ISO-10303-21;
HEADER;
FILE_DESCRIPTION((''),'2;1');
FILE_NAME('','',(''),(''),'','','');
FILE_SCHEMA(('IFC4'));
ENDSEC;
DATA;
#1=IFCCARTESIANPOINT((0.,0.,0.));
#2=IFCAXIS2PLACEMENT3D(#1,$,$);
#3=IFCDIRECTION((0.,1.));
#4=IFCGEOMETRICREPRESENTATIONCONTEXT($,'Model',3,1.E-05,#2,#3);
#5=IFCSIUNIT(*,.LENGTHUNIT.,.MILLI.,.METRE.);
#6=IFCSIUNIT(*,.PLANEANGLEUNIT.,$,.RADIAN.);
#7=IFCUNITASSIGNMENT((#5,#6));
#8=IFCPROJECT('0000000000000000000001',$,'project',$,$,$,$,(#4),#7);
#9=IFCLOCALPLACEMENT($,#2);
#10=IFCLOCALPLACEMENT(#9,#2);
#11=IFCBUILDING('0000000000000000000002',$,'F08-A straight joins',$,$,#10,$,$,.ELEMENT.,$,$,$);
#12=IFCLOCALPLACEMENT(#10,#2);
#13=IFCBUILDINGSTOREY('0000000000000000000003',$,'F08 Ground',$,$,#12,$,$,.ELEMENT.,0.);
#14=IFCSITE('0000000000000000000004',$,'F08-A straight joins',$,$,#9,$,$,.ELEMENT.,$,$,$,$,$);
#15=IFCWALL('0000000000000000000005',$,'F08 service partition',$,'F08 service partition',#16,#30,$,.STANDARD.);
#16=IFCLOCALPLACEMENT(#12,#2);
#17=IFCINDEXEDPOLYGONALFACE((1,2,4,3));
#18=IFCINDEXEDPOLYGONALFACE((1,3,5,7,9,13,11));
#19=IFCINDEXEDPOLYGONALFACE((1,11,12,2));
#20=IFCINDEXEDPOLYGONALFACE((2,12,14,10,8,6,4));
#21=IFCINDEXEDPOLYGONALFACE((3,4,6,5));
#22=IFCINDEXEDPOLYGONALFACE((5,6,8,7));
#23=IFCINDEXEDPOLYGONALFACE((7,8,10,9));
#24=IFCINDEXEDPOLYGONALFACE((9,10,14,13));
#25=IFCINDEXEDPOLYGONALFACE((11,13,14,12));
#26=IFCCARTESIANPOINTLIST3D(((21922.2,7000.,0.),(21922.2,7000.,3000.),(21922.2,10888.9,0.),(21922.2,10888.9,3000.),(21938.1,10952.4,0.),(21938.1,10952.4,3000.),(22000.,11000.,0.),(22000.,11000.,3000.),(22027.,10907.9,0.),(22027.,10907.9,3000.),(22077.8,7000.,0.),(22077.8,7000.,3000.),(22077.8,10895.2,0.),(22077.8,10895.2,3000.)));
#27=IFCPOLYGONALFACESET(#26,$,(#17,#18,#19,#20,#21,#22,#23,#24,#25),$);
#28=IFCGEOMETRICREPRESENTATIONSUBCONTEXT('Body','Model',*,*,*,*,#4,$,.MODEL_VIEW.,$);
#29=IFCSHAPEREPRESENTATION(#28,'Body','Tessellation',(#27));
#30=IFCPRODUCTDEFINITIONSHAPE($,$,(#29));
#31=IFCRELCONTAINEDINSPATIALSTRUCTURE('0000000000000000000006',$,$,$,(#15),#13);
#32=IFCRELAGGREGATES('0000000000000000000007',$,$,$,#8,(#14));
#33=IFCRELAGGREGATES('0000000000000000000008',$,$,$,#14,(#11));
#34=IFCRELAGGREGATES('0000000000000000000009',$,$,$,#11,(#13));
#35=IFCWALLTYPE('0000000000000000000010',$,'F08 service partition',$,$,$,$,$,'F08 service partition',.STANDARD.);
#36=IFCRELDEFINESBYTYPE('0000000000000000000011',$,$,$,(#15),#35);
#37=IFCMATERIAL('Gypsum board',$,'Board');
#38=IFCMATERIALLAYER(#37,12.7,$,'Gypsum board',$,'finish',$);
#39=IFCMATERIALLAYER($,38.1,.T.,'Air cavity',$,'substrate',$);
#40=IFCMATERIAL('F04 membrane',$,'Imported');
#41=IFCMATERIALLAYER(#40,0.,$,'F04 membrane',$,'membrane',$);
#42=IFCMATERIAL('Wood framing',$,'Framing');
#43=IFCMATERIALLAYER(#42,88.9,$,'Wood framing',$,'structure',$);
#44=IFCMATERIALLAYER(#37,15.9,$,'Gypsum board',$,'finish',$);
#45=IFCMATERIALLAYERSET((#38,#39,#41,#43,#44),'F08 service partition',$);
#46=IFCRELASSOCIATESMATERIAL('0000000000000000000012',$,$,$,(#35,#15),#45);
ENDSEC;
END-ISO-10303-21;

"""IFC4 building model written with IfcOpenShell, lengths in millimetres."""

from ifc_helpers import new_model, si_unit, direction, frame, origin, place, context, subcontext, project, spatial, polyline, outline, extrude, material, layer, layer_set, layer_usage, type_object, element, save


model = new_model("IFC4")

# Units and contexts
model_context = context("Model", 3, precision=1e-05, world=origin(), true_north=direction((0.0, 1.0)))
body_context = subcontext(model_context, "Body", "Model", "MODEL_VIEW")
ifc_project = project(units=[si_unit("LENGTHUNIT", "METRE", prefix="MILLI"), si_unit("PLANEANGLEUNIT", "RADIAN")], contexts=[model_context])

# Site, building, storey
site_placement = place(None, origin())
site = spatial("IfcSite", under=ifc_project, at=site_placement, Name="F08-A straight joins", CompositionType="ELEMENT")
building_placement = place(site_placement, origin())
building = spatial("IfcBuilding", under=site, at=building_placement, Name="F08-A straight joins", CompositionType="ELEMENT")
storey_placement = place(building_placement, origin())
storey = spatial("IfcBuildingStorey", under=building, at=storey_placement, Name="F08 Ground", CompositionType="ELEMENT", Elevation=0.0)

# Shared definitions
ifc_material_1 = material(Name="F04 membrane", Category="Imported")
ifc_material_2 = material(Name="Wood framing", Category="Framing")
ifc_material_3 = material(Name="Gypsum board", Category="Board")

# Wall
ifc_layer_1 = layer(ifc_material_3, 12.7, Name="Gypsum board", Category="finish")
ifc_layer_2 = layer(None, 38.1, ventilated=True, Name="Air cavity", Category="substrate")
ifc_layer_3 = layer(ifc_material_1, 0.0, Name="F04 membrane", Category="membrane")
ifc_layer_4 = layer(ifc_material_2, 88.9, Name="Wood framing", Category="structure")
ifc_layer_5 = layer(ifc_material_3, 15.9, Name="Gypsum board", Category="finish")
ifc_layer_set_1 = layer_set([ifc_layer_1, ifc_layer_2, ifc_layer_3, ifc_layer_4, ifc_layer_5], Name="F08 service partition")
wall_type_1 = type_object("IfcWallType", Name="F08 service partition", ElementType="F08 service partition", PredefinedType="STANDARD", material=ifc_layer_set_1)
ifc_layer_usage_1 = layer_usage(ifc_layer_set_1, "AXIS2", "NEGATIVE", 77.8)
wall_1_placement = place(storey_placement, frame((22000.0, 11000.0, 0.0), z_axis=(0.0, 0.0, 1.0), x_axis=(0.0, -1.0, 0.0)))
element("IfcWall", 1, at=wall_1_placement, inside=storey, type_object=wall_type_1, material=ifc_layer_usage_1, Name="F08 service partition", ObjectType="F08 service partition", PredefinedType="STANDARD", context=body_context, shape_type="SweptSolid", body=[
    extrude(outline(polyline([(111.1, -77.8), (4000.0, -77.8), (4000.0, 77.8), (104.8, 77.8), (92.1, 27.0), (0.0, 0.0), (47.6, -61.9), (111.1, -77.8)])), origin(), (0.0, 0.0, 1.0), 3000.0),
])

save(model, "model.ifc")
